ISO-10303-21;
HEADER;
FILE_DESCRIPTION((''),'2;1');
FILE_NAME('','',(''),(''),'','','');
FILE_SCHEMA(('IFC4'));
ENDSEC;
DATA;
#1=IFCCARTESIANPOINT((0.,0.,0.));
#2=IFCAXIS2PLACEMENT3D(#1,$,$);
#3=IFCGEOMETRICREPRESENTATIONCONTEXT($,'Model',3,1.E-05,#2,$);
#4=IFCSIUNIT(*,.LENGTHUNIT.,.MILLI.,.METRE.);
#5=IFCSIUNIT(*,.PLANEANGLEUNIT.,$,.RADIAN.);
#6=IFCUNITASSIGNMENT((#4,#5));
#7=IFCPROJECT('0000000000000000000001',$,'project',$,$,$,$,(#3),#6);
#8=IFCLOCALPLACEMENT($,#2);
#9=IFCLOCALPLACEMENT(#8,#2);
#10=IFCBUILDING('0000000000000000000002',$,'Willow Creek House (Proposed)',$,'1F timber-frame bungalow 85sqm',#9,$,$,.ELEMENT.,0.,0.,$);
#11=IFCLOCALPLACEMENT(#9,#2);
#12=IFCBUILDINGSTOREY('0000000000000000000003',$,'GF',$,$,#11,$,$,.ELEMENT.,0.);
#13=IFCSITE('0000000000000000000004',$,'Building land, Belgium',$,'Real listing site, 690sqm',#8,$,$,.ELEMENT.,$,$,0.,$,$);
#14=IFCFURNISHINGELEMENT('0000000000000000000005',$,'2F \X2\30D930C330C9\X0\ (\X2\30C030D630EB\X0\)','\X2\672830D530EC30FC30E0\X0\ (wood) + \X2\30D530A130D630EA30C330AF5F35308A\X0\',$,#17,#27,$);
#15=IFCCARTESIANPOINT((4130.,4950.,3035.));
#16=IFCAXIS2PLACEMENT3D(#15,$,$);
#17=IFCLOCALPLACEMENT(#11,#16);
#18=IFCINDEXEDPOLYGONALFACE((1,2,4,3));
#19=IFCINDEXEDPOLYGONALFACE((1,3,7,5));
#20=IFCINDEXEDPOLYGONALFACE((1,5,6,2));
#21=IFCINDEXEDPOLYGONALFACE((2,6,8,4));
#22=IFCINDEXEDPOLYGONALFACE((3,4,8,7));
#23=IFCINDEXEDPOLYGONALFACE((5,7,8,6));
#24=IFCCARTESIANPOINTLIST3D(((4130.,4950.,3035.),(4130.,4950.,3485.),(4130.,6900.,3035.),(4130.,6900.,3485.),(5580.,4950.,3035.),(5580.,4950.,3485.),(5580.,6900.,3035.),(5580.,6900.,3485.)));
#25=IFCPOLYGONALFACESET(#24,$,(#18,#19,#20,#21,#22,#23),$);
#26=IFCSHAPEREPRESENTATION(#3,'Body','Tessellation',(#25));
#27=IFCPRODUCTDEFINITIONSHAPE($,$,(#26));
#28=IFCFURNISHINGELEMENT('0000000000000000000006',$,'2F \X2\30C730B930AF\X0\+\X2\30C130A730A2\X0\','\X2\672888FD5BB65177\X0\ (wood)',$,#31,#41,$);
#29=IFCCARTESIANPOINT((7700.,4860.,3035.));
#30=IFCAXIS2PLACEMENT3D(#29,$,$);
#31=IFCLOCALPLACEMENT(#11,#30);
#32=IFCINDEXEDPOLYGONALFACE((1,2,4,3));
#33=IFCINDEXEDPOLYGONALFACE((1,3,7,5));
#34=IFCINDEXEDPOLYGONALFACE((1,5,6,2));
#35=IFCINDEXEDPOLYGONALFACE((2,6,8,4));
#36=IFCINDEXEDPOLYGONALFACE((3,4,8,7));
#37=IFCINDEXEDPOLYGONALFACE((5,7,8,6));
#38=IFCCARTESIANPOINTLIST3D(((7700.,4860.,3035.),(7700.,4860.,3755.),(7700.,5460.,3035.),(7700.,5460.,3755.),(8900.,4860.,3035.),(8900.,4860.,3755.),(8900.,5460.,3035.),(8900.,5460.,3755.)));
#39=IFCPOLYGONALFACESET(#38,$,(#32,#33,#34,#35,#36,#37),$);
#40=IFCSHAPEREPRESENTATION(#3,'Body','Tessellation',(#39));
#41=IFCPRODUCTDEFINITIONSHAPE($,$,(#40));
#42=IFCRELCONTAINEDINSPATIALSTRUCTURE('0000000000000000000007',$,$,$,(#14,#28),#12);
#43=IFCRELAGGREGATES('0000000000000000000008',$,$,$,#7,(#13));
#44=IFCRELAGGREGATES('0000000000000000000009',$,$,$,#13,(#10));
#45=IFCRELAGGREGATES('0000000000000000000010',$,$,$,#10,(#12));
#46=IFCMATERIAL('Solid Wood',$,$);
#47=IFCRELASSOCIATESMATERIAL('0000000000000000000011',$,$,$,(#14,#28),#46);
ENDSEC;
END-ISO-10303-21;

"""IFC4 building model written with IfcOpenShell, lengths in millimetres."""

from ifc_helpers import new_model, si_unit, frame, frame_2d, origin, place, context, project, spatial, rectangle, extrude, material, element, save


model = new_model("IFC4")

# Units and contexts
model_context = context("Model", 3, precision=1e-05, world=origin())
ifc_project = project(units=[si_unit("LENGTHUNIT", "METRE", prefix="MILLI"), si_unit("PLANEANGLEUNIT", "RADIAN")], contexts=[model_context])

# Site, building, storey
site_placement = place(None, origin())
site = spatial("IfcSite", under=ifc_project, at=site_placement, Name="Building land, Belgium", ObjectType="Real listing site, 690sqm", CompositionType="ELEMENT", RefElevation=0.0)
building_placement = place(site_placement, origin())
building = spatial("IfcBuilding", under=site, at=building_placement, Name="Willow Creek House (Proposed)", ObjectType="1F timber-frame bungalow 85sqm", CompositionType="ELEMENT", ElevationOfRefHeight=0.0, ElevationOfTerrain=0.0)
storey_placement = place(building_placement, origin())
storey = spatial("IfcBuildingStorey", under=building, at=storey_placement, Name="GF", CompositionType="ELEMENT", Elevation=0.0)

# Shared definitions
ifc_material_1 = material(Name="Solid Wood")

# Furnishing elements
furnishing_1_placement = place(storey_placement, frame((4130.0, 4950.0, 3035.0)))
element("IfcFurnishingElement", 1, at=furnishing_1_placement, inside=storey, material=ifc_material_1, Name="2F ベッド (ダブル)", Description="木フレーム (wood) + ファブリック張り", context=model_context, shape_type="SweptSolid", body=[
    extrude(rectangle(XDim=1450.0, YDim=1950.0, at=frame_2d((725.0, 975.0))), frame((4130.0, 4950.0, 3035.0)), (0.0, 0.0, 1.0), 450.0),
])
furnishing_2_placement = place(storey_placement, frame((7700.0, 4860.0, 3035.0)))
element("IfcFurnishingElement", 2, at=furnishing_2_placement, inside=storey, material=ifc_material_1, Name="2F デスク+チェア", Description="木製家具 (wood)", context=model_context, shape_type="SweptSolid", body=[
    extrude(rectangle(XDim=1200.0, YDim=600.0, at=frame_2d((600.0, 300.0))), frame((7700.0, 4860.0, 3035.0)), (0.0, 0.0, 1.0), 720.0),
])

save(model, "model.ifc")
